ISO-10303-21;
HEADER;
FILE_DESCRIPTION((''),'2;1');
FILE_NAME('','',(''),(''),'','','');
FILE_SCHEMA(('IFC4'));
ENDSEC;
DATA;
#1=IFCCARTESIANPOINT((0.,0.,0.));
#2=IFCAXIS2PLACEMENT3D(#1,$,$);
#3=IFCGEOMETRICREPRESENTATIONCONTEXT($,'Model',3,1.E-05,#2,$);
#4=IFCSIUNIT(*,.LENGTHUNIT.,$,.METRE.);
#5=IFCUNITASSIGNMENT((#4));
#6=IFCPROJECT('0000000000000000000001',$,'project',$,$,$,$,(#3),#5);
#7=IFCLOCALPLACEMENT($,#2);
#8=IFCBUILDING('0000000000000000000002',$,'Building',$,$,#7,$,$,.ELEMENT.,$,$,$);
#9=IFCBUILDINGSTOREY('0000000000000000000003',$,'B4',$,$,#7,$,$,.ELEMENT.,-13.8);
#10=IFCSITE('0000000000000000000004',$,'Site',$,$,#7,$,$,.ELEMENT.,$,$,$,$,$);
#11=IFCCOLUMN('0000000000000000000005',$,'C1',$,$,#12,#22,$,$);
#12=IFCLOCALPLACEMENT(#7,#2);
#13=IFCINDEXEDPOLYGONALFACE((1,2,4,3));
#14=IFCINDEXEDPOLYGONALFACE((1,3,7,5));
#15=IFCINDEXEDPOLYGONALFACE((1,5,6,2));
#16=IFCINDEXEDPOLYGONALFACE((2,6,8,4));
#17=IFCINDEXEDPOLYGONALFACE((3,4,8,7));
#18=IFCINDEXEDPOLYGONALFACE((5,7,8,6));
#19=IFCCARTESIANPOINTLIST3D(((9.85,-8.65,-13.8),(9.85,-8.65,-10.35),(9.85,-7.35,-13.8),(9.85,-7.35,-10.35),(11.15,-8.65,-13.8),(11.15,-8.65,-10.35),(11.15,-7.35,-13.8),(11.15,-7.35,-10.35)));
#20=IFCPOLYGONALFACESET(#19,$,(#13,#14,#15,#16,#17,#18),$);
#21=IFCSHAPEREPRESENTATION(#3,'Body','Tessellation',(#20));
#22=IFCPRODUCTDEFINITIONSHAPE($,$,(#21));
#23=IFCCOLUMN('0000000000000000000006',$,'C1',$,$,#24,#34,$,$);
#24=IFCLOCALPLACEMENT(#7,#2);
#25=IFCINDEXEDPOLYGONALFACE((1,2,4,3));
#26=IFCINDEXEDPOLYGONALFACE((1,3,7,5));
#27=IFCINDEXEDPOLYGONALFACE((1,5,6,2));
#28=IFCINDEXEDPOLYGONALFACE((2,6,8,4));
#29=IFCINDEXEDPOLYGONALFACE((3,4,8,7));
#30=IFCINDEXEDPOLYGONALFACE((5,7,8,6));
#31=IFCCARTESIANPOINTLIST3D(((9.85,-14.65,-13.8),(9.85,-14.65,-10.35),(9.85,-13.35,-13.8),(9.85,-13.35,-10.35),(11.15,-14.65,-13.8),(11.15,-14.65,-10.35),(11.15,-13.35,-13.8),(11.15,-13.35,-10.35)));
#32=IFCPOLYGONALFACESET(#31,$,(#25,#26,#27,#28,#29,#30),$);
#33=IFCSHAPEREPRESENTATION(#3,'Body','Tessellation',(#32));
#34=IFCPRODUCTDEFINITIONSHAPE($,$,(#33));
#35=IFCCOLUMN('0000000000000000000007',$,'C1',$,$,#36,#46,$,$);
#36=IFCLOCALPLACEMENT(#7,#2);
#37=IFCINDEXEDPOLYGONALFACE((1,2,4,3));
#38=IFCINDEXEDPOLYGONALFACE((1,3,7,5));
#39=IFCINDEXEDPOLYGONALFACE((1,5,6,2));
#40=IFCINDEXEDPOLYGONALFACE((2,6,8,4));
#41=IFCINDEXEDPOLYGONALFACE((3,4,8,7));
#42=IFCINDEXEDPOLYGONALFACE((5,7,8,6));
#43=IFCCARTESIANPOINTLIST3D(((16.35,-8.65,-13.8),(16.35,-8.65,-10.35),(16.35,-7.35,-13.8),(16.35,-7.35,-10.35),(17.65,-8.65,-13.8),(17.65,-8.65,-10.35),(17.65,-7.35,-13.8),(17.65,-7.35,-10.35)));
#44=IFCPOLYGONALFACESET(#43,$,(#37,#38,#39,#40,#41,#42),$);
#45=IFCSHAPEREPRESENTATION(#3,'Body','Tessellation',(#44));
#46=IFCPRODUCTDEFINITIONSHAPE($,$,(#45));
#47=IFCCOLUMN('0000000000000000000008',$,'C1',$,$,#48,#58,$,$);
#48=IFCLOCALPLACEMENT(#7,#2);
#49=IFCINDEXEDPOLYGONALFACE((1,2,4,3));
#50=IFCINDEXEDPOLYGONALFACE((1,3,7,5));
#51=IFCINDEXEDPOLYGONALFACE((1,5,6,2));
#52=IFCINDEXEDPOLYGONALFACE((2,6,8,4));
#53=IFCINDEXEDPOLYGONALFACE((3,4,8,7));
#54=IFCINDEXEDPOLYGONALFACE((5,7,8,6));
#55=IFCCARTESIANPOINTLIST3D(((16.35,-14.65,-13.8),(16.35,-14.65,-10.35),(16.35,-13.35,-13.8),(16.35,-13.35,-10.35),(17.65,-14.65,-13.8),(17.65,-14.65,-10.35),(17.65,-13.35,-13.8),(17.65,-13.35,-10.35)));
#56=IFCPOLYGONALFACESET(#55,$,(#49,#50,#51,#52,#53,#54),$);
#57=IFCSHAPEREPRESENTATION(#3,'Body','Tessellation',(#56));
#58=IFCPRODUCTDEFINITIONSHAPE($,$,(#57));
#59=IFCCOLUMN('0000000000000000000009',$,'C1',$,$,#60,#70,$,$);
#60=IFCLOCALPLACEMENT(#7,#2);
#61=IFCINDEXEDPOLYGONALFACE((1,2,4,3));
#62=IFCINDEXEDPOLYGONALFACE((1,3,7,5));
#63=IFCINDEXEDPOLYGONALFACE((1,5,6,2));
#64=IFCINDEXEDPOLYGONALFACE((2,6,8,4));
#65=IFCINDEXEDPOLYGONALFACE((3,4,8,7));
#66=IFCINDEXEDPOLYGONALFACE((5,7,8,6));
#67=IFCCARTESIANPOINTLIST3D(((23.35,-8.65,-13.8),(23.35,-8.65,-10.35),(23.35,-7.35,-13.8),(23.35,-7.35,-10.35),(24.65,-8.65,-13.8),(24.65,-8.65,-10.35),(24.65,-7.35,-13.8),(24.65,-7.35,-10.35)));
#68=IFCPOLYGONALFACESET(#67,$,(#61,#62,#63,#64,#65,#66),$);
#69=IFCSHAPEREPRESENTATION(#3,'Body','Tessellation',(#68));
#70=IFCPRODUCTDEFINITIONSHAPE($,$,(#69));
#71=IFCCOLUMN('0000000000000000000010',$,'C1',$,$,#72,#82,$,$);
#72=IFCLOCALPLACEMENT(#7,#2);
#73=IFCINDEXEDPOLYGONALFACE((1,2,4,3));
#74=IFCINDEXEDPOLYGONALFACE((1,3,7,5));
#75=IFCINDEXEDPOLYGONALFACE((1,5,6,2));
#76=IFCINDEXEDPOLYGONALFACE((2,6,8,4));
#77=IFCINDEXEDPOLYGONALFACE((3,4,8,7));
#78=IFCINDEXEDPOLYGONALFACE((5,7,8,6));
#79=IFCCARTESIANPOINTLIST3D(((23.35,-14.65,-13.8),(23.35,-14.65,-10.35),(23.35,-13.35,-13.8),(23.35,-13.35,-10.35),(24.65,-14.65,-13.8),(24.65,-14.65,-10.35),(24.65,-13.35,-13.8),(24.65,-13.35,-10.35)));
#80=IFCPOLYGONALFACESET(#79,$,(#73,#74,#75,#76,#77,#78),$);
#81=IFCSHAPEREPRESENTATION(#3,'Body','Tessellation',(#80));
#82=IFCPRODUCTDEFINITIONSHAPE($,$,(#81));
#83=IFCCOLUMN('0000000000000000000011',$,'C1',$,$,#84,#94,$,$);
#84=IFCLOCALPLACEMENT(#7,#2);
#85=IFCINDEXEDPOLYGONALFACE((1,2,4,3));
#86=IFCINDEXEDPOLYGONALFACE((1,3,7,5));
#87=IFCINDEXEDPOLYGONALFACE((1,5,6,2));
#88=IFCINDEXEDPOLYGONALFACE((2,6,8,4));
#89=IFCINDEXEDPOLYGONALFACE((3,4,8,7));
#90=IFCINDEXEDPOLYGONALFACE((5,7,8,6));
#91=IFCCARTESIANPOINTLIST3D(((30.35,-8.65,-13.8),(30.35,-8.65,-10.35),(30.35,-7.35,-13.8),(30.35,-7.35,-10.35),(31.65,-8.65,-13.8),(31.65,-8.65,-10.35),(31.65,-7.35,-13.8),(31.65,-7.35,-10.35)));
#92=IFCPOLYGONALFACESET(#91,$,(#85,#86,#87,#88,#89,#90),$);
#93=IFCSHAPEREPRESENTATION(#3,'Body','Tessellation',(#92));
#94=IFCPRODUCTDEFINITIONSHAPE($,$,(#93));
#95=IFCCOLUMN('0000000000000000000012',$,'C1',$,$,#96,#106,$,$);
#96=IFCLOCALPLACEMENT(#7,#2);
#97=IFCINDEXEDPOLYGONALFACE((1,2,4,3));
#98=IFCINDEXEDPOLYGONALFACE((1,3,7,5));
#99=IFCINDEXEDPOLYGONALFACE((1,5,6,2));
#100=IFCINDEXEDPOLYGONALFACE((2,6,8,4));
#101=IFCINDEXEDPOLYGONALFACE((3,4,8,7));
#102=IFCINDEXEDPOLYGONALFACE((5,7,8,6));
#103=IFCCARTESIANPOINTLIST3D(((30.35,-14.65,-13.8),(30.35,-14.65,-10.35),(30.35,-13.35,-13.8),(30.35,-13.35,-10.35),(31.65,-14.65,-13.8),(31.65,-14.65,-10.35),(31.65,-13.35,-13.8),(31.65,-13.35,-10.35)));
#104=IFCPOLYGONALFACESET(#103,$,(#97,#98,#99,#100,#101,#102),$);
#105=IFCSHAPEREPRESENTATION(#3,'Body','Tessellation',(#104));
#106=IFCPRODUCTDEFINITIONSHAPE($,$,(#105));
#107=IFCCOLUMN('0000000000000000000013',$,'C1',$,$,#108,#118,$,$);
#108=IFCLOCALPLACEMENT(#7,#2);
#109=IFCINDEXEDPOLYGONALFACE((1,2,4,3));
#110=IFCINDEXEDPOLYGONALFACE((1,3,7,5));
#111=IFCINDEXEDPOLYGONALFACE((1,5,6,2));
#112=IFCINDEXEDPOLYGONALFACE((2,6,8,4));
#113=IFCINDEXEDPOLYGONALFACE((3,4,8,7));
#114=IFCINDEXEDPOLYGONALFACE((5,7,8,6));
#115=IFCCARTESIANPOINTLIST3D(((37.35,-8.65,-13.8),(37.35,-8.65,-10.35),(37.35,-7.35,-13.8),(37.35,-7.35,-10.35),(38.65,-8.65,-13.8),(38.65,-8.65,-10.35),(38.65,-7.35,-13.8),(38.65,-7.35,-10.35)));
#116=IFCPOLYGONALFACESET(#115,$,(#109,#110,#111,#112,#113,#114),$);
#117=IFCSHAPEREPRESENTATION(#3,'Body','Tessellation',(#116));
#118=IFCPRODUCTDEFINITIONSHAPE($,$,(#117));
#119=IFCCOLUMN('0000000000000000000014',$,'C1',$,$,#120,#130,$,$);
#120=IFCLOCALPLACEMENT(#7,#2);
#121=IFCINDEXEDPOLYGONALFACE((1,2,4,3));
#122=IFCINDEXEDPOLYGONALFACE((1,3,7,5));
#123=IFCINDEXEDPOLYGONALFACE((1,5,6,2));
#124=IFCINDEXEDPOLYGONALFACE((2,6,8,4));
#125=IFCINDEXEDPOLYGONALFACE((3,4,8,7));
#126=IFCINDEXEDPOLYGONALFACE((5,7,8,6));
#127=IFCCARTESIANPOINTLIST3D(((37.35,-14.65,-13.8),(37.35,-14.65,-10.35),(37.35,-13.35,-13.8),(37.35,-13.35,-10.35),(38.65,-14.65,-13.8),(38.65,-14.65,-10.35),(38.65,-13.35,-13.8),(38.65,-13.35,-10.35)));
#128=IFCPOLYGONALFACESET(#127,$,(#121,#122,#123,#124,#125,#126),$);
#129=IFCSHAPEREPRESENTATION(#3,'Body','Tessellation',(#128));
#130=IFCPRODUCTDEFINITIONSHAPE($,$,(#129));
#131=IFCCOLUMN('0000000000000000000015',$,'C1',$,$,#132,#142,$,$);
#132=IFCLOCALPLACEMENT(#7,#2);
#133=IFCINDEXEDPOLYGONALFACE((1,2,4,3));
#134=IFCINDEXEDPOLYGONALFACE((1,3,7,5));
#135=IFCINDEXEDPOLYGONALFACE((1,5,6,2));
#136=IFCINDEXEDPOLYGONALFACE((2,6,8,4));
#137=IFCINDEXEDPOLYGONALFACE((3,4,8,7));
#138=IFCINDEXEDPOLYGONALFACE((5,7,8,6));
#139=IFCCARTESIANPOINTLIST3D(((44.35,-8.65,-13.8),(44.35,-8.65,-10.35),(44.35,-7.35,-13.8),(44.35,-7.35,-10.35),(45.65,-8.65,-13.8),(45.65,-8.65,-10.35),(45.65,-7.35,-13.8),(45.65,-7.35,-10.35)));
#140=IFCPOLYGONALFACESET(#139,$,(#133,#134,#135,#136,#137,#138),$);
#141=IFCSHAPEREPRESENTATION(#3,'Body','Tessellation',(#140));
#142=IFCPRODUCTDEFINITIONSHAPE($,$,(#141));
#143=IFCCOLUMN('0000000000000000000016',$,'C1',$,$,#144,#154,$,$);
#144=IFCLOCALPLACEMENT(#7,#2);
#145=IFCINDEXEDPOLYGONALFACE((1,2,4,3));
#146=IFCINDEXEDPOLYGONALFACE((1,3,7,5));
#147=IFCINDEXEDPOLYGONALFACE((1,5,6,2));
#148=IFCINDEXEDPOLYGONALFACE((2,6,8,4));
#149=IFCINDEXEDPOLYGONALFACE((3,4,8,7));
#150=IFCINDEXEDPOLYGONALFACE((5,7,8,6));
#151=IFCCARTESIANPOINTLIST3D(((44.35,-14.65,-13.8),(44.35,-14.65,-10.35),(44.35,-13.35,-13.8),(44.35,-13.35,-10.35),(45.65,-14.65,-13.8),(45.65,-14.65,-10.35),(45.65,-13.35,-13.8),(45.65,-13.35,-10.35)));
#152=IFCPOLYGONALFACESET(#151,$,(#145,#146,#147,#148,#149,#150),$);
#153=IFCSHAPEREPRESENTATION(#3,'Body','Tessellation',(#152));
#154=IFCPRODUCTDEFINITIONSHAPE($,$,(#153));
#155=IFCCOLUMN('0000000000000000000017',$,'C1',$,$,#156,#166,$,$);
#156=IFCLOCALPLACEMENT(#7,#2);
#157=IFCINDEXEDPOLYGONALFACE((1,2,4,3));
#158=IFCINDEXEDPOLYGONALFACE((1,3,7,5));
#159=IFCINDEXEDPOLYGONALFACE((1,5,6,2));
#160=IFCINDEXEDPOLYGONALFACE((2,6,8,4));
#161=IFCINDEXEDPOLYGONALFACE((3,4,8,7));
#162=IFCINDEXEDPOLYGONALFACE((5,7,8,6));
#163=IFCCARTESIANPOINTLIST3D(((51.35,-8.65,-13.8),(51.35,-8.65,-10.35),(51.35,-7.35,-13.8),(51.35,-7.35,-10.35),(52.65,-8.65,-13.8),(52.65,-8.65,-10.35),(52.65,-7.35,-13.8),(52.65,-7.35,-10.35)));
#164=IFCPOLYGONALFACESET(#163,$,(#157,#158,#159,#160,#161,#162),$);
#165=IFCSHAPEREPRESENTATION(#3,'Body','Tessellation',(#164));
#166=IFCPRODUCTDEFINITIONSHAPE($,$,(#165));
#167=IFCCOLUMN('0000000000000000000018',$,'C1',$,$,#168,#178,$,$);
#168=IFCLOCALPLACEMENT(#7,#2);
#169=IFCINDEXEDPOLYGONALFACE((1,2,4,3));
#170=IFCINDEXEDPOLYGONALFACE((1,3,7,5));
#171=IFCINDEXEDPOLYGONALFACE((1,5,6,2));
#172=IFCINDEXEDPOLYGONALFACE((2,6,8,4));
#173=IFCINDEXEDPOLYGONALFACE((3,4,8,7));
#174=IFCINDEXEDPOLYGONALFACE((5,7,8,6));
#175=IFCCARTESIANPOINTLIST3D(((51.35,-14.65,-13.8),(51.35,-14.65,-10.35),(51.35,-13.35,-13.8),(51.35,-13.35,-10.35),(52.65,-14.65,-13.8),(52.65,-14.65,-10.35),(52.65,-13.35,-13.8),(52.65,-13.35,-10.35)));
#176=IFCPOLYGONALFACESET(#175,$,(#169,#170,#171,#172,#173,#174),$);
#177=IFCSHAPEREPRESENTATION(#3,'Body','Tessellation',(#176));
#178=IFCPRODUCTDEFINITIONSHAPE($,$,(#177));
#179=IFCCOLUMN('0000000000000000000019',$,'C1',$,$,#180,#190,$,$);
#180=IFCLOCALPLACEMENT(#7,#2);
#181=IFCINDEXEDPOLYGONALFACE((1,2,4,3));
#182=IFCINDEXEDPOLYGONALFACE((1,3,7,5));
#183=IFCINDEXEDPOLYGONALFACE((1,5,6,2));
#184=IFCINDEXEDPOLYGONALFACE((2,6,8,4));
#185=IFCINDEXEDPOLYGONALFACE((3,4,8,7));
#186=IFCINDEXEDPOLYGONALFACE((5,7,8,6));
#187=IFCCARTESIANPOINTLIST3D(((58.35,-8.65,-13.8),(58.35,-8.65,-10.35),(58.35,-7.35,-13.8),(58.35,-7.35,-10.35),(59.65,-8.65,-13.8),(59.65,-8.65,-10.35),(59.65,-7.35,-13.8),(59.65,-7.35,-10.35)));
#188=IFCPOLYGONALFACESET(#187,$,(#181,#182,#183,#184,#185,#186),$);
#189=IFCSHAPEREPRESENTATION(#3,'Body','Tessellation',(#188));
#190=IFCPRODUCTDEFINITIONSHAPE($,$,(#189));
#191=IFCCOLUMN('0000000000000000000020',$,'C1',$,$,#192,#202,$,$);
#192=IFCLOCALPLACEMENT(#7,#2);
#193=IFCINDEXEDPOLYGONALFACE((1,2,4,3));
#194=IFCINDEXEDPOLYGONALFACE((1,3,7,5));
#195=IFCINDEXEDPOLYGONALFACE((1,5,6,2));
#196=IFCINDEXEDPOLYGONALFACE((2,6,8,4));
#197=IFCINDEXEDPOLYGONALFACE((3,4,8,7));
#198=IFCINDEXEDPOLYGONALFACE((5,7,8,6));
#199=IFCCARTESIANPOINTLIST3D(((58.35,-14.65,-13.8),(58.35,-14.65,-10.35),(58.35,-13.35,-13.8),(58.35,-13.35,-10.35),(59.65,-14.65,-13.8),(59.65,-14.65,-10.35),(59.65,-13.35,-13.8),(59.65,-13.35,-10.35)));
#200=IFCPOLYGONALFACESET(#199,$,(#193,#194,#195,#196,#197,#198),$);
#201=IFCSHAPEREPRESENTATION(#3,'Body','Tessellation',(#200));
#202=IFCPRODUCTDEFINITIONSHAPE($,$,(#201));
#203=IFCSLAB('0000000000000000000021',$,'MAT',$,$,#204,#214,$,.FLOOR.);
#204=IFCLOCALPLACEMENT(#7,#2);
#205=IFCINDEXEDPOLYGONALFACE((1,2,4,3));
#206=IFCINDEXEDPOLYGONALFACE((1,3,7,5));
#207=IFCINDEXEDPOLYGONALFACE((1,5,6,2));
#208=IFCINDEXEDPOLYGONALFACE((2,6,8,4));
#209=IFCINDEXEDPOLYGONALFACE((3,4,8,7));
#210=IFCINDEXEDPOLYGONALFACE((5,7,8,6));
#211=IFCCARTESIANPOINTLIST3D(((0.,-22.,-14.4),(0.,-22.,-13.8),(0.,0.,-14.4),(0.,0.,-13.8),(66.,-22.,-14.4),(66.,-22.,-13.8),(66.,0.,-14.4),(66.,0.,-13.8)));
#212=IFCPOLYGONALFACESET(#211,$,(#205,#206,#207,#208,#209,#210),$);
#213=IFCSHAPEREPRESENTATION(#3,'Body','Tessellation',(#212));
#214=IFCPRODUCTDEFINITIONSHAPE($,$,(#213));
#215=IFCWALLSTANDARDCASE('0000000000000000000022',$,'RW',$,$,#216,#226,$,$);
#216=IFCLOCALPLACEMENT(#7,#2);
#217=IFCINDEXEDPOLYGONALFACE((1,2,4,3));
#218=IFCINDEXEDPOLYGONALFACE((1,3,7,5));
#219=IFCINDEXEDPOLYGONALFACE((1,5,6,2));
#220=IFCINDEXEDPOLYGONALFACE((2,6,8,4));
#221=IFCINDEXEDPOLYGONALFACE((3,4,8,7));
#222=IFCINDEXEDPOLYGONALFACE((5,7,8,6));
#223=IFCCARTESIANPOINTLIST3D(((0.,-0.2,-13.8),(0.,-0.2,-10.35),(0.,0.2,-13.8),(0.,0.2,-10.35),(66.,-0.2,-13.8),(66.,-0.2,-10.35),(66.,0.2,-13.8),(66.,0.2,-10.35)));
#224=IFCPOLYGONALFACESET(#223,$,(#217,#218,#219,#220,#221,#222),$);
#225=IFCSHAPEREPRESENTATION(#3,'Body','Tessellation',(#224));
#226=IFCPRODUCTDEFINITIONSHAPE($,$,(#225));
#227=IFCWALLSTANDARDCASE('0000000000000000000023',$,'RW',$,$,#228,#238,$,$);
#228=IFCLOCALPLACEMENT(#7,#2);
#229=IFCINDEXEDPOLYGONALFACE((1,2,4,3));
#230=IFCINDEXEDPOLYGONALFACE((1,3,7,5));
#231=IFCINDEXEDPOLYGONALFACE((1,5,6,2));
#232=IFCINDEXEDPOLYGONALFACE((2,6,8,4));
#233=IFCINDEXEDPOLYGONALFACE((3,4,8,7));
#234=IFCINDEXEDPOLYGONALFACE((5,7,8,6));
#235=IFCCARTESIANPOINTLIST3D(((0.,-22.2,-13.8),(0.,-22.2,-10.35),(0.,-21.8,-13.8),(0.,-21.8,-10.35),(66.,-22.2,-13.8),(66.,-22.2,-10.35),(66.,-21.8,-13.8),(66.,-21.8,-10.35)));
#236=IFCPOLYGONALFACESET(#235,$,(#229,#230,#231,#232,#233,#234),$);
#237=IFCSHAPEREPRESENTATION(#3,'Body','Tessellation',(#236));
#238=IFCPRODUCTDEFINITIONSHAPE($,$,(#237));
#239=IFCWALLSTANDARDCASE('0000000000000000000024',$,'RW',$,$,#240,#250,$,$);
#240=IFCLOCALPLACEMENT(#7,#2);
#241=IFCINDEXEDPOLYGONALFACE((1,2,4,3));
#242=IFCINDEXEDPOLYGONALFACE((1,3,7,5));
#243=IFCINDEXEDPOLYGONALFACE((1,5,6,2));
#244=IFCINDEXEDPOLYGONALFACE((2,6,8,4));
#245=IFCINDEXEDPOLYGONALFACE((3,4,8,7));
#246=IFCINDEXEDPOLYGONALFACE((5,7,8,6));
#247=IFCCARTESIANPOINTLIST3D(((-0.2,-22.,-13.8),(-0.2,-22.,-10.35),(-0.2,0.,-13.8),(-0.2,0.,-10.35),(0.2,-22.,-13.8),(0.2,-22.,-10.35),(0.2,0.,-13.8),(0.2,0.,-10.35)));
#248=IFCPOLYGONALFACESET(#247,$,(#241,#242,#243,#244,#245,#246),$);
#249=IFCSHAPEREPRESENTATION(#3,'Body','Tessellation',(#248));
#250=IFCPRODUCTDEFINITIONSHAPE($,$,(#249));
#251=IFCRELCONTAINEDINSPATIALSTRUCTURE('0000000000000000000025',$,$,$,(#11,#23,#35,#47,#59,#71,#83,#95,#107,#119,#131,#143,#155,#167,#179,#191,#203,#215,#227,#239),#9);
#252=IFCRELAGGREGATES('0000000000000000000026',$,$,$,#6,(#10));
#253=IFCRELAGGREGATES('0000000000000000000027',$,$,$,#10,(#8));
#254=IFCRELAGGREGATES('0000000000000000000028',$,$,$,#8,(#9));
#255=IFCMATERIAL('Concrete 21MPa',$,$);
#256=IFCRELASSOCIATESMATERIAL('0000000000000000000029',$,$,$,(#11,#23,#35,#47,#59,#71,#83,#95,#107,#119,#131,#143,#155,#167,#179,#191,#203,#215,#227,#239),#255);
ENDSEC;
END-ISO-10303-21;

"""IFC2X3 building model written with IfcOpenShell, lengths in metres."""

from ifc_helpers import new_model, si_unit, frame, origin, origin_2d, place, context, project, spatial, rectangle, extrude, material, element, save


model = new_model("IFC2X3")

# Units and contexts
model_context = context("Model", 3, precision=1e-05, world=origin())
ifc_project = project(units=[si_unit("LENGTHUNIT", "METRE")], contexts=[model_context])

# Site, building, storey
placement = place(None, origin())
site = spatial("IfcSite", under=ifc_project, at=placement, Name="Site", CompositionType="ELEMENT")
building = spatial("IfcBuilding", under=site, at=placement, Name="Building", CompositionType="ELEMENT")
storey = spatial("IfcBuildingStorey", under=building, at=placement, Name="B4", CompositionType="ELEMENT", Elevation=-13.8)

# Columns
ifc_material_1 = material(Name="Concrete 21MPa")
for number, where, name in (
    (1, (10.5, -8.0, -13.8), "C1"),
    (2, (10.5, -14.0, -13.8), "C1"),
    (3, (17.0, -8.0, -13.8), "C1"),
    (4, (17.0, -14.0, -13.8), "C1"),
    (5, (24.0, -8.0, -13.8), "C1"),
    (6, (24.0, -14.0, -13.8), "C1"),
    (7, (31.0, -8.0, -13.8), "C1"),
    (8, (31.0, -14.0, -13.8), "C1"),
    (9, (38.0, -8.0, -13.8), "C1"),
    (10, (38.0, -14.0, -13.8), "C1"),
    (11, (45.0, -8.0, -13.8), "C1"),
    (12, (45.0, -14.0, -13.8), "C1"),
    (13, (52.0, -8.0, -13.8), "C1"),
    (14, (52.0, -14.0, -13.8), "C1"),
    (15, (59.0, -8.0, -13.8), "C1"),
    (16, (59.0, -14.0, -13.8), "C1"),
):
    element("IfcColumn", number, at=place(None, frame(where)), inside=storey, material=ifc_material_1, Name=name, context=model_context, shape_type="SweptSolid", body=[
        extrude(rectangle(XDim=1.3, YDim=1.3, at=origin_2d()), origin(), (0.0, 0.0, 1.0), 3.45),
    ])

# Slab
slab_placement = place(None, frame((33.0, -11.0, -14.4)))
element("IfcSlab", 17, at=slab_placement, inside=storey, material=ifc_material_1, Name="MAT", PredefinedType="FLOOR", context=model_context, shape_type="SweptSolid", body=[
    extrude(rectangle(XDim=66.0, YDim=22.0, at=origin_2d()), origin(), (0.0, 0.0, 1.0), 0.6),
])

# Walls
for number, where, name in (
    (18, (33.0, 0.0, -13.8), "RW"),
    (19, (33.0, -22.0, -13.8), "RW"),
):
    element("IfcWallStandardCase", number, at=place(None, frame(where)), inside=storey, material=ifc_material_1, Name=name, context=model_context, shape_type="SweptSolid", body=[
        extrude(rectangle(XDim=66.0, YDim=0.4, at=origin_2d()), origin(), (0.0, 0.0, 1.0), 3.45),
    ])
for number, where, name in (
    (20, (0.0, -11.0, -13.8), "RW"),
):
    element("IfcWallStandardCase", number, at=place(None, frame(where)), inside=storey, material=ifc_material_1, Name=name, context=model_context, shape_type="SweptSolid", body=[
        extrude(rectangle(XDim=0.4, YDim=22.0, at=origin_2d()), origin(), (0.0, 0.0, 1.0), 3.45),
    ])

save(model, "model.ifc")
